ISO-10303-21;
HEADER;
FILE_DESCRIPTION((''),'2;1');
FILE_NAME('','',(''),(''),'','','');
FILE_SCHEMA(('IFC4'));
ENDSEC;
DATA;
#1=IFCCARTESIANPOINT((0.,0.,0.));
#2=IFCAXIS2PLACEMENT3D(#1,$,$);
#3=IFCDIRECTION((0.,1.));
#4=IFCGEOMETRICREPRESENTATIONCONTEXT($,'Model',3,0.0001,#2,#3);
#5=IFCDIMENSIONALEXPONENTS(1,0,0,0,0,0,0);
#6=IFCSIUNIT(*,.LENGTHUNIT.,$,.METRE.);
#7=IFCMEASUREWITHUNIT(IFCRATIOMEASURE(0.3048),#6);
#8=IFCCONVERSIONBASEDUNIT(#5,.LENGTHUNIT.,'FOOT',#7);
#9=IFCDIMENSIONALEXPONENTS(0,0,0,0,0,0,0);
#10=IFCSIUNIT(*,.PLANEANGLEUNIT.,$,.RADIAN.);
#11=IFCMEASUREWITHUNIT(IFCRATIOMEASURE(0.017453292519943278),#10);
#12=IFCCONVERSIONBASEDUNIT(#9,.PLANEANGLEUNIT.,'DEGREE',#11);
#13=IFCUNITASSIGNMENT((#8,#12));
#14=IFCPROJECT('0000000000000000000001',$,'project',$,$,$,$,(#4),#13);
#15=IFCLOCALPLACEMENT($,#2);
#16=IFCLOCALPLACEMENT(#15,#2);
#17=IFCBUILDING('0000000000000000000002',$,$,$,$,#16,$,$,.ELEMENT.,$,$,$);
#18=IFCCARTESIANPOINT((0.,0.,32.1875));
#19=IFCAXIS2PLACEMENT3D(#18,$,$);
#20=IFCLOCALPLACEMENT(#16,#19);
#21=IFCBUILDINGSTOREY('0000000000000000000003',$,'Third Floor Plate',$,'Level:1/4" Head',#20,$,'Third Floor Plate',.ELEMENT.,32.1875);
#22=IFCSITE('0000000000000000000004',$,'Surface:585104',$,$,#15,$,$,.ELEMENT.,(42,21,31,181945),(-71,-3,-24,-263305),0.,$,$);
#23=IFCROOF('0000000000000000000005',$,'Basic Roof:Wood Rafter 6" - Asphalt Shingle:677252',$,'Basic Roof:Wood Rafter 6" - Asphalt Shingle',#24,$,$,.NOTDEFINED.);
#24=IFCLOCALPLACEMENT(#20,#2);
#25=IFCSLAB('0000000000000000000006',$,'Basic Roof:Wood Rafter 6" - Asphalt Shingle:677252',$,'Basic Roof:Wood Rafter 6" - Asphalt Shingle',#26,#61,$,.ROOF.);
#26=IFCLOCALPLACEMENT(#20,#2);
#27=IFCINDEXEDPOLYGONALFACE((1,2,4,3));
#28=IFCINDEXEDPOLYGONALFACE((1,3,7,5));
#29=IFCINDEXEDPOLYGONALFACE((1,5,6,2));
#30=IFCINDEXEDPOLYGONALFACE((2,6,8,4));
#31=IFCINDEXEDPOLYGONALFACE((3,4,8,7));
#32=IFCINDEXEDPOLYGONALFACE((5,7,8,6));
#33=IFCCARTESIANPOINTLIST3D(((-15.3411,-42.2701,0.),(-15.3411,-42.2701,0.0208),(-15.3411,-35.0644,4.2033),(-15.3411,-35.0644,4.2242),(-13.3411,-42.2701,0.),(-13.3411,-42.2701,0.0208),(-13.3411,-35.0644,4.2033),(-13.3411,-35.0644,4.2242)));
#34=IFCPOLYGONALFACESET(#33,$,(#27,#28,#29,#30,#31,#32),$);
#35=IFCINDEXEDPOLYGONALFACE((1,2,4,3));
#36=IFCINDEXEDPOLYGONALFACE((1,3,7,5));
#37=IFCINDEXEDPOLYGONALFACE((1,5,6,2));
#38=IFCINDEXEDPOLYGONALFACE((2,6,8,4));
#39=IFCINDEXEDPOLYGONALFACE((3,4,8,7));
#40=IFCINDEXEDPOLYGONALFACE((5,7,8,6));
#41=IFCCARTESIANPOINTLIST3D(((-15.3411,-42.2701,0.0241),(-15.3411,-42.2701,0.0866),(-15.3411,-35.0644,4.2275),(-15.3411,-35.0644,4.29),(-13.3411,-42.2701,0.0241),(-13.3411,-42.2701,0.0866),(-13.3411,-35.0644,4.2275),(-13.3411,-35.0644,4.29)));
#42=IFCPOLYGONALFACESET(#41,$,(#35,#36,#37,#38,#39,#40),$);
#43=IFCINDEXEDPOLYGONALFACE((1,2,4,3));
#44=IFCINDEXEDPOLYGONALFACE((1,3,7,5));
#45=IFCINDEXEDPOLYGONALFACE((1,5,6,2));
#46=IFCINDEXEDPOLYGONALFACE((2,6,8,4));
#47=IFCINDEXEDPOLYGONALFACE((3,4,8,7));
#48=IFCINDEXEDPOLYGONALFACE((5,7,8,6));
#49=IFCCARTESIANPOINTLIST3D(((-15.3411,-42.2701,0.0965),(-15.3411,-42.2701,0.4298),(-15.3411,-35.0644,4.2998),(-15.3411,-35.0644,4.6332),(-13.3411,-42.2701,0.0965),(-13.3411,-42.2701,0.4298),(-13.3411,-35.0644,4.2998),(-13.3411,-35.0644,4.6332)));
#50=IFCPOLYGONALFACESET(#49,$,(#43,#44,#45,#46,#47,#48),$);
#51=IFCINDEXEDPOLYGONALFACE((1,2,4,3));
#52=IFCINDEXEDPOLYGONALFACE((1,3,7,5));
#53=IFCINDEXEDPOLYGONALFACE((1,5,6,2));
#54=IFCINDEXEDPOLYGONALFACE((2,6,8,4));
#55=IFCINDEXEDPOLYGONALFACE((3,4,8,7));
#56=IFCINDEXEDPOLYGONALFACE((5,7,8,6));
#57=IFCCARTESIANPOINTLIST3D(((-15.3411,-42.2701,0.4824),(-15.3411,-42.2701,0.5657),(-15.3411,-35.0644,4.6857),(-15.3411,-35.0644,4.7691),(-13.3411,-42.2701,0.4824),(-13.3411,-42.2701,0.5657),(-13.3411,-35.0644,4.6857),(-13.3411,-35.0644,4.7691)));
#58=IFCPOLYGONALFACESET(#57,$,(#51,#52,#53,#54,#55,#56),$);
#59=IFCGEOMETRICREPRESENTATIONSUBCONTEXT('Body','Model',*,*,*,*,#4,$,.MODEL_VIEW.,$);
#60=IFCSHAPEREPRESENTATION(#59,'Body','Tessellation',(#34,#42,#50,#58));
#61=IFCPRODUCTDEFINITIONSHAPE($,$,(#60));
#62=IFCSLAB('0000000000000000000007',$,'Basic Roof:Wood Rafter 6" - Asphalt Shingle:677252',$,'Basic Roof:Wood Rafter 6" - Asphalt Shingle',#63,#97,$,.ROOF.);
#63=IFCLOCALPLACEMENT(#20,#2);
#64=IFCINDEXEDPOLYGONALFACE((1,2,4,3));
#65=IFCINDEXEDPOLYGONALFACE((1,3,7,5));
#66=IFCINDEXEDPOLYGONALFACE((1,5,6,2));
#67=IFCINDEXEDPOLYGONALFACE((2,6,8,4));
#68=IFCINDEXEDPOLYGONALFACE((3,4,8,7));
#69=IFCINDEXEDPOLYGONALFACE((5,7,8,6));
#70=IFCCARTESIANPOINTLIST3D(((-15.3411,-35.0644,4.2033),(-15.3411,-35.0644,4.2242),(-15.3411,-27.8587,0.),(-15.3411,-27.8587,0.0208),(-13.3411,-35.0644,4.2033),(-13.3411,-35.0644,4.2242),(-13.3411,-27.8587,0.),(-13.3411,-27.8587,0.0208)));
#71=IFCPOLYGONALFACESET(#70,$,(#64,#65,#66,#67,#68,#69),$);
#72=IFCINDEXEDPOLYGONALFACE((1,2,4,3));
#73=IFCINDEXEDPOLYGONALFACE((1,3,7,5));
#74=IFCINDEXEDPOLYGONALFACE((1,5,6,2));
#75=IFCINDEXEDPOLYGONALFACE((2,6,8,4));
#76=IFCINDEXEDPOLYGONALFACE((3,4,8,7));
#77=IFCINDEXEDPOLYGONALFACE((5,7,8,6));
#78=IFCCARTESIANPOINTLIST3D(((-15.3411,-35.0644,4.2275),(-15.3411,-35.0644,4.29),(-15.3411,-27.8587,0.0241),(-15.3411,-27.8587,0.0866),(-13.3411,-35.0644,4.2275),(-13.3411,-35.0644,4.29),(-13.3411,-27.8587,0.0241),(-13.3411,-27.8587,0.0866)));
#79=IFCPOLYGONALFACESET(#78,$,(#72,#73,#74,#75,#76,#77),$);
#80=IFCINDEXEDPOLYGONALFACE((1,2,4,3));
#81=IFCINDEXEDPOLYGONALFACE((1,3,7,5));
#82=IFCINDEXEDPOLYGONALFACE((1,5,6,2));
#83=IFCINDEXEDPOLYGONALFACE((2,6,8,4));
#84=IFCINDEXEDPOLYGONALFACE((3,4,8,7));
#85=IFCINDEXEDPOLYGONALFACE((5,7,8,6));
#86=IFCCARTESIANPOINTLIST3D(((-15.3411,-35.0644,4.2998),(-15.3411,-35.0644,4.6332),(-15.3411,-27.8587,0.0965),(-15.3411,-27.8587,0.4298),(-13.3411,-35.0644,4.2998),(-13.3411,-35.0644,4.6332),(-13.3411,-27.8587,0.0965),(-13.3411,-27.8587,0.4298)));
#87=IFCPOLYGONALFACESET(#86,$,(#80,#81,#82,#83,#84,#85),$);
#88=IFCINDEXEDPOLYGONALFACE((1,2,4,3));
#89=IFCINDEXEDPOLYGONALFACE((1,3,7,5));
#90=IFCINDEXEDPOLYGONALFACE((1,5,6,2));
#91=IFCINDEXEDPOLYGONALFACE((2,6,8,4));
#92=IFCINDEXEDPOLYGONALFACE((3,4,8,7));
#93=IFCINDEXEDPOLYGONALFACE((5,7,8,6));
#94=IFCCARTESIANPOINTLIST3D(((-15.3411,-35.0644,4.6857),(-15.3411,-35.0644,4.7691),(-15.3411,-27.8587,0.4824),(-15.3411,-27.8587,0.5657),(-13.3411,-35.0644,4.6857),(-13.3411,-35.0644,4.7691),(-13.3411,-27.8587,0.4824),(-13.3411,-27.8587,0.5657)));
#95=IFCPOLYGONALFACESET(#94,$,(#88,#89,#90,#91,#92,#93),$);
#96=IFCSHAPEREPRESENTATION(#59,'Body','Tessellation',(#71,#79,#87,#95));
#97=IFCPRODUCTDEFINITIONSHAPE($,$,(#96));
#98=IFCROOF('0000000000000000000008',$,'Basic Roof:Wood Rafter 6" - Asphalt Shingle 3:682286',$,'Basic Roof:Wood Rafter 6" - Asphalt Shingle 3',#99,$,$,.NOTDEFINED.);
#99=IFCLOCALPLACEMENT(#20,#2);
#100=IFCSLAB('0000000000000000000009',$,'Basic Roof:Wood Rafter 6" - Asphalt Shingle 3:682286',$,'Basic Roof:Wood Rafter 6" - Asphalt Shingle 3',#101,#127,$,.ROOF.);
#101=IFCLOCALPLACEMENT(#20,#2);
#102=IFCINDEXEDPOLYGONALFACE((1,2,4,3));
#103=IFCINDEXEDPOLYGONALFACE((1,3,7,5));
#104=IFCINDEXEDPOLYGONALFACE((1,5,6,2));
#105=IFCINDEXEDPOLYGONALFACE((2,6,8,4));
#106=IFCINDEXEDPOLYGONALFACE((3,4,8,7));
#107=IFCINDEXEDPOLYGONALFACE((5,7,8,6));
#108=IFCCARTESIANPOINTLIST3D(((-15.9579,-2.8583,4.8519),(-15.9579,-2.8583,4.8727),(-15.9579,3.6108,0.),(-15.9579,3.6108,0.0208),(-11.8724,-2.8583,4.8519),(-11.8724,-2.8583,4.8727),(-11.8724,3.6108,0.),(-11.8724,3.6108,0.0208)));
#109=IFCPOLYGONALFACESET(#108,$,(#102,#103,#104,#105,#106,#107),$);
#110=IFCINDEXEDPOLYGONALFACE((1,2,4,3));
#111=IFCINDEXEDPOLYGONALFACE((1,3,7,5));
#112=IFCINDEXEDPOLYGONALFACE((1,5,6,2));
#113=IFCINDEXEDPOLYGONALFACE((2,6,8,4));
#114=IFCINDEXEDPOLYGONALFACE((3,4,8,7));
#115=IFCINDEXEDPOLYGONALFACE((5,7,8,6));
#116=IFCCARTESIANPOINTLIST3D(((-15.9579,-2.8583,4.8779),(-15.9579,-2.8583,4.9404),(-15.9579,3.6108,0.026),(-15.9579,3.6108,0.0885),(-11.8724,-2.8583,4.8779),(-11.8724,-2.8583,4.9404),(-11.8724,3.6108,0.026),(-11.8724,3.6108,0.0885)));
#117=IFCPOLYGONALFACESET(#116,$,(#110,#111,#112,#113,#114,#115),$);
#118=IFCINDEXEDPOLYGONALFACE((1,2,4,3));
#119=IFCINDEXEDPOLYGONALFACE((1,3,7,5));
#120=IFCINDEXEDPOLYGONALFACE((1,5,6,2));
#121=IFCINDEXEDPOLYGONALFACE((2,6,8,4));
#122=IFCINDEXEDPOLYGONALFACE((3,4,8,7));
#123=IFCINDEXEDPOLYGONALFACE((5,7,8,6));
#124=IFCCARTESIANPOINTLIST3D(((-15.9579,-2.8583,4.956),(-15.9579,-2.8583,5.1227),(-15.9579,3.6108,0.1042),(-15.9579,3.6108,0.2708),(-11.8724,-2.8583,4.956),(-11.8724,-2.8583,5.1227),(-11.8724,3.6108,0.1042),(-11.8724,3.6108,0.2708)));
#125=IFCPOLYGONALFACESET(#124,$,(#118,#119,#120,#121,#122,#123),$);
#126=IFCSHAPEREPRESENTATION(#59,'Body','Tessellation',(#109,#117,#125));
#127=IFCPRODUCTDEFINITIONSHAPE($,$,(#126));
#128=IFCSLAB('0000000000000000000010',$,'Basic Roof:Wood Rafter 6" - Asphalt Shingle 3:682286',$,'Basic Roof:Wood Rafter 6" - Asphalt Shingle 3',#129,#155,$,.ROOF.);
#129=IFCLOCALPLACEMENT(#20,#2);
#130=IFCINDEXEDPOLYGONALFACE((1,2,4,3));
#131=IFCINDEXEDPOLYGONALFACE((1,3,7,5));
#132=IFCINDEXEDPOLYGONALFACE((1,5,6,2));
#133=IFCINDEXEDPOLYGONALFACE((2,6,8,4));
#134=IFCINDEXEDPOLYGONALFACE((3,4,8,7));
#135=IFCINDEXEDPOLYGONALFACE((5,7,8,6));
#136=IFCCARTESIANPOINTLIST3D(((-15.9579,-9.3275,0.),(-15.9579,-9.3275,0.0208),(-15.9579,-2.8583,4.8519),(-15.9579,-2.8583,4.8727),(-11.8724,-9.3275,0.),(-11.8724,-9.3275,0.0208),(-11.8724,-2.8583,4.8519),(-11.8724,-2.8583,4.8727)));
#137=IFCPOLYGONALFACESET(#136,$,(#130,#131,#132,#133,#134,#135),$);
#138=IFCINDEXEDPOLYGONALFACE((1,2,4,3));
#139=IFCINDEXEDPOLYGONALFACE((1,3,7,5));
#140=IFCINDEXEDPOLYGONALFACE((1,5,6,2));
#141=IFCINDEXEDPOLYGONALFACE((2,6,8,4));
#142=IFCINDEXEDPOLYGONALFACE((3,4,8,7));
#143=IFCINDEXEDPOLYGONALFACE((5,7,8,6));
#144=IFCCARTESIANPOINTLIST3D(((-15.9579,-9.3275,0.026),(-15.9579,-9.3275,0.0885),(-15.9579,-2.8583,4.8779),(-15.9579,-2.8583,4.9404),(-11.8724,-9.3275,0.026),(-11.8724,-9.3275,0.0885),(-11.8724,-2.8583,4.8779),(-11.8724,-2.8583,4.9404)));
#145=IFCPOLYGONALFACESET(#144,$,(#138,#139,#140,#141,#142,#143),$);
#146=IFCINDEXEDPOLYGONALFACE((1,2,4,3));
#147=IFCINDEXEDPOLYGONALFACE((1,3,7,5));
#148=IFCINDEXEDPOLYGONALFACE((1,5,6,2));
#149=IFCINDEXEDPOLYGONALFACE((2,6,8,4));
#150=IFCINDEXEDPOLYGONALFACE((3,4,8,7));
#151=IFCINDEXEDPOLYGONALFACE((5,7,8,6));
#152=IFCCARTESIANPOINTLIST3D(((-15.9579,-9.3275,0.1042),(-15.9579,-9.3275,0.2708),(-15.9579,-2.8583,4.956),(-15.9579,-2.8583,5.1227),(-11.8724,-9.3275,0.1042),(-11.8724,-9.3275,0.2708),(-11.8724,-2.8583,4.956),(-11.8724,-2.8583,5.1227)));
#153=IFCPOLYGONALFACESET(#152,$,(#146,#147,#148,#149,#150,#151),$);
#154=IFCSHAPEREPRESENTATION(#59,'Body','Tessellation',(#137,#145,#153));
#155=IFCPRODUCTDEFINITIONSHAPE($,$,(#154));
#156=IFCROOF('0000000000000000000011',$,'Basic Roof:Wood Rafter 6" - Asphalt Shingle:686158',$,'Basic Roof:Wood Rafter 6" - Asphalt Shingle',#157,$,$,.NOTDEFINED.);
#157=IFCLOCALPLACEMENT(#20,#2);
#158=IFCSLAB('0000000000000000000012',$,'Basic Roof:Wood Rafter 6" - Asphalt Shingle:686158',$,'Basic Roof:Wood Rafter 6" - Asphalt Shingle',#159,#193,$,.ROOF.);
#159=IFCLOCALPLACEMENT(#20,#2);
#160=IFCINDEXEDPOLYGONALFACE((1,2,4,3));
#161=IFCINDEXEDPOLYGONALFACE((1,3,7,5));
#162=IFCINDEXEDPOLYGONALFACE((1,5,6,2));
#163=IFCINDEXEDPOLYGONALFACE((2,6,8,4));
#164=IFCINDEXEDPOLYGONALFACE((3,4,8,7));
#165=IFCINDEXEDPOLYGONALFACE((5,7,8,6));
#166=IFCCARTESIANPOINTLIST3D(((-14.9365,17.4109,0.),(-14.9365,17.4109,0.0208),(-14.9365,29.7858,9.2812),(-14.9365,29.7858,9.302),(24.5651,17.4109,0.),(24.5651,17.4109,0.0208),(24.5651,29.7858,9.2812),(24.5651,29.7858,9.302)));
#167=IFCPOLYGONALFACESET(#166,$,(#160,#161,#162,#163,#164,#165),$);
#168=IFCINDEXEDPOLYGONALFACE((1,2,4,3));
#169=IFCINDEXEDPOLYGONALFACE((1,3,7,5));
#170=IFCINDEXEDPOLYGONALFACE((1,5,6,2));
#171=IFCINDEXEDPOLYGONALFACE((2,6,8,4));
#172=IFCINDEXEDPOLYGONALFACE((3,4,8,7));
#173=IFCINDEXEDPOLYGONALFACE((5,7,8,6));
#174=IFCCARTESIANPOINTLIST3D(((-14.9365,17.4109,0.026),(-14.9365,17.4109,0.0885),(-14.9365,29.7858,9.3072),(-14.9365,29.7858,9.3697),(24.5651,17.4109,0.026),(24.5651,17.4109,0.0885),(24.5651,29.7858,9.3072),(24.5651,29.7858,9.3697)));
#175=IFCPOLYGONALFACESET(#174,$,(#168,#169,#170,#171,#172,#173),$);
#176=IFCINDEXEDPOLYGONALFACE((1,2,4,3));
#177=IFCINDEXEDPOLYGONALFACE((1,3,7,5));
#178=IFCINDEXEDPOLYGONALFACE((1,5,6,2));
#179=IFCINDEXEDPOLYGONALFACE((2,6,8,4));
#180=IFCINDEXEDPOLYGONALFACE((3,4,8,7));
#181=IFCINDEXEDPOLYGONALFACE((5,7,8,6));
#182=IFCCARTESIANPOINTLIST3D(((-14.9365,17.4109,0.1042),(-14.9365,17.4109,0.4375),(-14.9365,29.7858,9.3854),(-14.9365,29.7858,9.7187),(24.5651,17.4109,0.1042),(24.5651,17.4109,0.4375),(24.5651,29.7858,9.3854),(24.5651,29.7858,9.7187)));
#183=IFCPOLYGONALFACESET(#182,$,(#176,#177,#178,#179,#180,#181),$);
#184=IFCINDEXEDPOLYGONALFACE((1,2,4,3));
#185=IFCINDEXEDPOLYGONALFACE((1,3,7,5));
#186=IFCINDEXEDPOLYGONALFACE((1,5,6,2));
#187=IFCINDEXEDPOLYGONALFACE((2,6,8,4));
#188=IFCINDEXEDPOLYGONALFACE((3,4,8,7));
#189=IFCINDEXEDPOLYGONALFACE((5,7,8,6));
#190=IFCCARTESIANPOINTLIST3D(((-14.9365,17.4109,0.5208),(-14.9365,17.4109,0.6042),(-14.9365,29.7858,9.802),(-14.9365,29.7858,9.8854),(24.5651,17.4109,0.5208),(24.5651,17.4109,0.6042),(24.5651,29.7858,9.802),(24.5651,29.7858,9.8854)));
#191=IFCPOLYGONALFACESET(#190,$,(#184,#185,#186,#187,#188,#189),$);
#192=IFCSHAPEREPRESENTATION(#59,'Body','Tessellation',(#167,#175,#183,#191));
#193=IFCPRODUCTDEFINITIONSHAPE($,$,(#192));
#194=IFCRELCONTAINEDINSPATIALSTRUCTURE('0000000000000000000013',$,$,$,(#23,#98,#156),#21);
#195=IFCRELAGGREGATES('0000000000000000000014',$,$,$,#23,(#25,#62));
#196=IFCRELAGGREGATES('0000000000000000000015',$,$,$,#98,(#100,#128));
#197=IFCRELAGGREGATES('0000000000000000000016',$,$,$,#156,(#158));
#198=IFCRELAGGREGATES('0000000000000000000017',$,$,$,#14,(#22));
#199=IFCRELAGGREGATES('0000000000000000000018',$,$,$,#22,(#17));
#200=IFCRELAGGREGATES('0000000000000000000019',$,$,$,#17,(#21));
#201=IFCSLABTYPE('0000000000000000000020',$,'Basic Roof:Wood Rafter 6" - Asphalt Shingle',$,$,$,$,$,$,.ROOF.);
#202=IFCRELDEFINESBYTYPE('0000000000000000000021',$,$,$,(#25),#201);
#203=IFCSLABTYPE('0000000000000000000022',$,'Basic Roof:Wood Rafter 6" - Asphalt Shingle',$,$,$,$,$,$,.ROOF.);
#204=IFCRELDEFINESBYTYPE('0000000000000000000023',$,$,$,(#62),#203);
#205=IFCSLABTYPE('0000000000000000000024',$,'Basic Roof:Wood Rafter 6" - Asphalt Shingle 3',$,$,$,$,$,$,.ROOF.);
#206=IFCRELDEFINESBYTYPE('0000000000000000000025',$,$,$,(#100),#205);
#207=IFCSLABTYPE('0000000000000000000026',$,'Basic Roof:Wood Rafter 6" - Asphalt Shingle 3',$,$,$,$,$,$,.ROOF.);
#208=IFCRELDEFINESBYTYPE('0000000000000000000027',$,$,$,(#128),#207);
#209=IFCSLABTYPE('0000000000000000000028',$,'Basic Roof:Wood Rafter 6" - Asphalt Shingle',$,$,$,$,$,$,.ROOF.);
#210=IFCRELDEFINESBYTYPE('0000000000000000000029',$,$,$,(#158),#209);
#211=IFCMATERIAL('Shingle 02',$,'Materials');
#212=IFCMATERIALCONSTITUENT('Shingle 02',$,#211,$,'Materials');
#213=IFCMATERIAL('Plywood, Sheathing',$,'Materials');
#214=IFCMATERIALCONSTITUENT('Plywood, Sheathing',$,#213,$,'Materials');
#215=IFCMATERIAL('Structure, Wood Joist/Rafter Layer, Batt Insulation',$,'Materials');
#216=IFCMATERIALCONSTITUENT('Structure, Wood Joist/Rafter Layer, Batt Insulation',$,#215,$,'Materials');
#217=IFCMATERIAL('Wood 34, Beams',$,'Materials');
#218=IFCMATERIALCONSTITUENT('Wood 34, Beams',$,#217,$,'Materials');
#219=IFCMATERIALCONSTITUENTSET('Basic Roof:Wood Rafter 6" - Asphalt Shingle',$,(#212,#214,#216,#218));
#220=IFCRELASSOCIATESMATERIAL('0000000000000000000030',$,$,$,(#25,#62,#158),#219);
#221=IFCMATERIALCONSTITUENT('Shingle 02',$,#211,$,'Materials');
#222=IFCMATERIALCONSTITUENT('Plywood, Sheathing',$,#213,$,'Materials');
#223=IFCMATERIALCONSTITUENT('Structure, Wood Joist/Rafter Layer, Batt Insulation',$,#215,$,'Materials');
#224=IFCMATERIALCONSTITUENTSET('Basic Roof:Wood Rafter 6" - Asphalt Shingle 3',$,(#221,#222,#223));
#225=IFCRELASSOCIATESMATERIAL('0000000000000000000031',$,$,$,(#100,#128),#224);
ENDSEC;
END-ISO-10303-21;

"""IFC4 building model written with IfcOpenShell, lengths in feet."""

from ifc_helpers import new_model, entity, si_unit, converted_unit, direction, frame, origin, place, context, subcontext, project, spatial, indexed_curve, outline, extrude, material, constituent, constituent_set, type_object, element, aggregate, save


model = new_model("IFC4")

# Units and contexts
model_context = context("Model", 3, precision=0.0001, world=origin(), true_north=direction((0.0, 1.0)))
body_context = subcontext(model_context, "Body", "Model", "MODEL_VIEW")
ifc_project = project(units=[converted_unit("LENGTHUNIT", "FOOT", entity("IfcRatioMeasure", 0.3048), si_unit("LENGTHUNIT", "METRE"), dimensions=[1, 0, 0, 0, 0, 0, 0]), converted_unit("PLANEANGLEUNIT", "DEGREE", entity("IfcRatioMeasure", 0.017453292519943278), si_unit("PLANEANGLEUNIT", "RADIAN"), dimensions=[0, 0, 0, 0, 0, 0, 0])], contexts=[model_context])

# Site, building, storey
site_placement = place(None, origin())
site = spatial("IfcSite", under=ifc_project, at=site_placement, Name="Surface:585104", CompositionType="ELEMENT", RefLatitude=(42, 21, 31, 181945), RefLongitude=(-71, -3, -24, -263305), RefElevation=0.0)
building_placement = place(site_placement, origin())
building = spatial("IfcBuilding", under=site, at=building_placement, CompositionType="ELEMENT")
storey_placement = place(building_placement, frame((0.0, 0.0, 32.1875)))
storey = spatial("IfcBuildingStorey", under=building, at=storey_placement, Name="Third Floor Plate", ObjectType="Level:1/4\" Head", LongName="Third Floor Plate", CompositionType="ELEMENT", Elevation=32.1875)

# Roofs, slabs
ifc_material_1 = material(Name="Shingle 02", Category="Materials")
ifc_constituent_1 = constituent(ifc_material_1, Name="Shingle 02", Category="Materials")
ifc_material_2 = material(Name="Plywood, Sheathing", Category="Materials")
ifc_constituent_2 = constituent(ifc_material_2, Name="Plywood, Sheathing", Category="Materials")
ifc_material_3 = material(Name="Structure, Wood Joist/Rafter Layer, Batt Insulation", Category="Materials")
ifc_constituent_3 = constituent(ifc_material_3, Name="Structure, Wood Joist/Rafter Layer, Batt Insulation", Category="Materials")
ifc_material_4 = material(Name="Wood 34, Beams", Category="Materials")
ifc_constituent_4 = constituent(ifc_material_4, Name="Wood 34, Beams", Category="Materials")
ifc_constituent_set_1 = constituent_set(constituents=[ifc_constituent_1, ifc_constituent_2, ifc_constituent_3, ifc_constituent_4], Name="Basic Roof:Wood Rafter 6\" - Asphalt Shingle")
roof_1_placement = place(storey_placement, frame((-15.3411, -42.2701, 0.0)))
roof_1 = element("IfcRoof", 1, at=roof_1_placement, inside=storey, Name="Basic Roof:Wood Rafter 6\" - Asphalt Shingle:677252", ObjectType="Basic Roof:Wood Rafter 6\" - Asphalt Shingle", PredefinedType="NOTDEFINED")
slab_type_1 = type_object("IfcSlabType", Name="Basic Roof:Wood Rafter 6\" - Asphalt Shingle", PredefinedType="ROOF")
slab_1_placement = place(roof_1_placement, origin())
slab_1 = element("IfcSlab", 2, at=slab_1_placement, type_object=slab_type_1, material=ifc_constituent_set_1, Name="Basic Roof:Wood Rafter 6\" - Asphalt Shingle:677252", ObjectType="Basic Roof:Wood Rafter 6\" - Asphalt Shingle", PredefinedType="ROOF", context=body_context, shape_type="SweptSolid", body=[
    extrude(outline(indexed_curve([(1.0, 4.171), (-1.0, 4.171), (-1.0, -4.171), (1.0, -4.171), (1.0, 4.171)], self_intersect=False)), frame((1.0, 3.6029, 2.1017), z_axis=(0.0, -0.503871, 0.863779), x_axis=(1.0, 0.0, 0.0)), (0.0, 0.503871, 0.863779), 0.0208),
    extrude(outline(indexed_curve([(1.0, 4.171), (-1.0, 4.171), (-1.0, -4.171), (1.0, -4.171), (1.0, 4.171)], self_intersect=False)), frame((1.0, 3.6029, 2.1258), z_axis=(0.0, -0.503871, 0.863779), x_axis=(1.0, 0.0, 0.0)), (0.0, 0.503871, 0.863779), 0.0625),
    extrude(outline(indexed_curve([(1.0, 4.171), (-1.0, 4.171), (-1.0, -4.171), (1.0, -4.171), (1.0, 4.171)], self_intersect=False)), frame((1.0, 3.6029, 2.1981), z_axis=(0.0, -0.503871, 0.863779), x_axis=(1.0, 0.0, 0.0)), (0.0, 0.503871, 0.863779), 0.3333),
    extrude(outline(indexed_curve([(1.0, 4.171), (-1.0, 4.171), (-1.0, -4.171), (1.0, -4.171), (1.0, 4.171)], self_intersect=False)), frame((1.0, 3.6029, 2.584), z_axis=(0.0, -0.503871, 0.863779), x_axis=(1.0, 0.0, 0.0)), (0.0, 0.503871, 0.863779), 0.0833),
])
slab_type_2 = type_object("IfcSlabType", Name="Basic Roof:Wood Rafter 6\" - Asphalt Shingle", PredefinedType="ROOF")
slab_2_placement = place(roof_1_placement, origin())
slab_2 = element("IfcSlab", 3, at=slab_2_placement, type_object=slab_type_2, material=ifc_constituent_set_1, Name="Basic Roof:Wood Rafter 6\" - Asphalt Shingle:677252", ObjectType="Basic Roof:Wood Rafter 6\" - Asphalt Shingle", PredefinedType="ROOF", context=body_context, shape_type="SweptSolid", body=[
    extrude(outline(indexed_curve([(-1.0, 4.171), (-1.0, -4.171), (1.0, -4.171), (1.0, 4.171), (-1.0, 4.171)], self_intersect=False)), frame((1.0, 10.8086, 2.1017), z_axis=(0.0, 0.503871, 0.863779), x_axis=(1.0, 0.0, 0.0)), (0.0, -0.503871, 0.863779), 0.0208),
    extrude(outline(indexed_curve([(-1.0, 4.171), (-1.0, -4.171), (1.0, -4.171), (1.0, 4.171), (-1.0, 4.171)], self_intersect=False)), frame((1.0, 10.8086, 2.1258), z_axis=(0.0, 0.503871, 0.863779), x_axis=(1.0, 0.0, 0.0)), (0.0, -0.503871, 0.863779), 0.0625),
    extrude(outline(indexed_curve([(-1.0, 4.171), (-1.0, -4.171), (1.0, -4.171), (1.0, 4.171), (-1.0, 4.171)], self_intersect=False)), frame((1.0, 10.8086, 2.1981), z_axis=(0.0, 0.503871, 0.863779), x_axis=(1.0, 0.0, 0.0)), (0.0, -0.503871, 0.863779), 0.3333),
    extrude(outline(indexed_curve([(-1.0, 4.171), (-1.0, -4.171), (1.0, -4.171), (1.0, 4.171), (-1.0, 4.171)], self_intersect=False)), frame((1.0, 10.8086, 2.584), z_axis=(0.0, 0.503871, 0.863779), x_axis=(1.0, 0.0, 0.0)), (0.0, -0.503871, 0.863779), 0.0833),
])
aggregate(roof_1, [slab_1, slab_2])
roof_2_placement = place(storey_placement, frame((-15.9579, -9.3275, 0.0)))
roof_2 = element("IfcRoof", 4, at=roof_2_placement, inside=storey, Name="Basic Roof:Wood Rafter 6\" - Asphalt Shingle 3:682286", ObjectType="Basic Roof:Wood Rafter 6\" - Asphalt Shingle 3", PredefinedType="NOTDEFINED")
ifc_constituent_5 = constituent(ifc_material_1, Name="Shingle 02", Category="Materials")
ifc_constituent_6 = constituent(ifc_material_2, Name="Plywood, Sheathing", Category="Materials")
ifc_constituent_7 = constituent(ifc_material_3, Name="Structure, Wood Joist/Rafter Layer, Batt Insulation", Category="Materials")
ifc_constituent_set_2 = constituent_set(constituents=[ifc_constituent_5, ifc_constituent_6, ifc_constituent_7], Name="Basic Roof:Wood Rafter 6\" - Asphalt Shingle 3")
slab_type_3 = type_object("IfcSlabType", Name="Basic Roof:Wood Rafter 6\" - Asphalt Shingle 3", PredefinedType="ROOF")
slab_3_placement = place(roof_2_placement, origin())
slab_3 = element("IfcSlab", 5, at=slab_3_placement, type_object=slab_type_3, material=ifc_constituent_set_2, Name="Basic Roof:Wood Rafter 6\" - Asphalt Shingle 3:682286", ObjectType="Basic Roof:Wood Rafter 6\" - Asphalt Shingle 3", PredefinedType="ROOF", context=body_context, shape_type="SweptSolid", body=[
    extrude(outline(indexed_curve([(-2.0427, -4.0432), (2.0427, -4.0432), (2.0427, 4.0432), (-2.0427, 4.0432), (-2.0427, -4.0432)], self_intersect=False)), frame((2.0427, 9.7037, 2.4259), z_axis=(0.0, 0.6, 0.8), x_axis=(1.0, 0.0, 0.0)), (0.0, -0.6, 0.8), 0.0208),
    extrude(outline(indexed_curve([(-2.0427, -4.0432), (2.0427, -4.0432), (2.0427, 4.0432), (-2.0427, 4.0432), (-2.0427, -4.0432)], self_intersect=False)), frame((2.0427, 9.7037, 2.452), z_axis=(0.0, 0.6, 0.8), x_axis=(1.0, 0.0, 0.0)), (0.0, -0.6, 0.8), 0.0625),
    extrude(outline(indexed_curve([(-2.0427, -4.0432), (2.0427, -4.0432), (2.0427, 4.0432), (-2.0427, 4.0432), (-2.0427, -4.0432)], self_intersect=False)), frame((2.0427, 9.7037, 2.5301), z_axis=(0.0, 0.6, 0.8), x_axis=(1.0, 0.0, 0.0)), (0.0, -0.6, 0.8), 0.1667),
])
slab_type_4 = type_object("IfcSlabType", Name="Basic Roof:Wood Rafter 6\" - Asphalt Shingle 3", PredefinedType="ROOF")
slab_4_placement = place(roof_2_placement, origin())
slab_4 = element("IfcSlab", 6, at=slab_4_placement, type_object=slab_type_4, material=ifc_constituent_set_2, Name="Basic Roof:Wood Rafter 6\" - Asphalt Shingle 3:682286", ObjectType="Basic Roof:Wood Rafter 6\" - Asphalt Shingle 3", PredefinedType="ROOF", context=body_context, shape_type="SweptSolid", body=[
    extrude(outline(indexed_curve([(2.0427, -4.0432), (2.0427, 4.0432), (-2.0427, 4.0432), (-2.0427, -4.0432), (2.0427, -4.0432)], self_intersect=False)), frame((2.0427, 3.2346, 2.4259), z_axis=(0.0, -0.6, 0.8), x_axis=(1.0, 0.0, 0.0)), (0.0, 0.6, 0.8), 0.0208),
    extrude(outline(indexed_curve([(2.0427, -4.0432), (2.0427, 4.0432), (-2.0427, 4.0432), (-2.0427, -4.0432), (2.0427, -4.0432)], self_intersect=False)), frame((2.0427, 3.2346, 2.452), z_axis=(0.0, -0.6, 0.8), x_axis=(1.0, 0.0, 0.0)), (0.0, 0.6, 0.8), 0.0625),
    extrude(outline(indexed_curve([(2.0427, -4.0432), (2.0427, 4.0432), (-2.0427, 4.0432), (-2.0427, -4.0432), (2.0427, -4.0432)], self_intersect=False)), frame((2.0427, 3.2346, 2.5301), z_axis=(0.0, -0.6, 0.8), x_axis=(1.0, 0.0, 0.0)), (0.0, 0.6, 0.8), 0.1667),
])
aggregate(roof_2, [slab_3, slab_4])
roof_3_placement = place(storey_placement, frame((-14.9365, 17.4109, 0.0)))
roof_3 = element("IfcRoof", 7, at=roof_3_placement, inside=storey, Name="Basic Roof:Wood Rafter 6\" - Asphalt Shingle:686158", ObjectType="Basic Roof:Wood Rafter 6\" - Asphalt Shingle", PredefinedType="NOTDEFINED")
slab_type_5 = type_object("IfcSlabType", Name="Basic Roof:Wood Rafter 6\" - Asphalt Shingle", PredefinedType="ROOF")
slab_5_placement = place(roof_3_placement, origin())
slab_5 = element("IfcSlab", 8, at=slab_5_placement, type_object=slab_type_5, material=ifc_constituent_set_1, Name="Basic Roof:Wood Rafter 6\" - Asphalt Shingle:686158", ObjectType="Basic Roof:Wood Rafter 6\" - Asphalt Shingle", PredefinedType="ROOF", context=body_context, shape_type="SweptSolid", body=[
    extrude(outline(indexed_curve([(19.7508, 7.7343), (-19.7508, 7.7343), (-19.7508, -7.7343), (19.7508, -7.7343), (19.7508, 7.7343)], self_intersect=False)), frame((19.7508, 6.1875, 4.6406), z_axis=(0.0, -0.6, 0.8), x_axis=(1.0, 0.0, 0.0)), (0.0, 0.6, 0.8), 0.0208),
    extrude(outline(indexed_curve([(19.7508, 7.7343), (-19.7508, 7.7343), (-19.7508, -7.7343), (19.7508, -7.7343), (19.7508, 7.7343)], self_intersect=False)), frame((19.7508, 6.1875, 4.6666), z_axis=(0.0, -0.6, 0.8), x_axis=(1.0, 0.0, 0.0)), (0.0, 0.6, 0.8), 0.0625),
    extrude(outline(indexed_curve([(19.7508, 7.7343), (-19.7508, 7.7343), (-19.7508, -7.7343), (19.7508, -7.7343), (19.7508, 7.7343)], self_intersect=False)), frame((19.7508, 6.1875, 4.7448), z_axis=(0.0, -0.6, 0.8), x_axis=(1.0, 0.0, 0.0)), (0.0, 0.6, 0.8), 0.3333),
    extrude(outline(indexed_curve([(19.7508, 7.7343), (-19.7508, 7.7343), (-19.7508, -7.7343), (19.7508, -7.7343), (19.7508, 7.7343)], self_intersect=False)), frame((19.7508, 6.1875, 5.1614), z_axis=(0.0, -0.6, 0.8), x_axis=(1.0, 0.0, 0.0)), (0.0, 0.6, 0.8), 0.0833),
])
aggregate(roof_3, [slab_5])

save(model, "model.ifc")
